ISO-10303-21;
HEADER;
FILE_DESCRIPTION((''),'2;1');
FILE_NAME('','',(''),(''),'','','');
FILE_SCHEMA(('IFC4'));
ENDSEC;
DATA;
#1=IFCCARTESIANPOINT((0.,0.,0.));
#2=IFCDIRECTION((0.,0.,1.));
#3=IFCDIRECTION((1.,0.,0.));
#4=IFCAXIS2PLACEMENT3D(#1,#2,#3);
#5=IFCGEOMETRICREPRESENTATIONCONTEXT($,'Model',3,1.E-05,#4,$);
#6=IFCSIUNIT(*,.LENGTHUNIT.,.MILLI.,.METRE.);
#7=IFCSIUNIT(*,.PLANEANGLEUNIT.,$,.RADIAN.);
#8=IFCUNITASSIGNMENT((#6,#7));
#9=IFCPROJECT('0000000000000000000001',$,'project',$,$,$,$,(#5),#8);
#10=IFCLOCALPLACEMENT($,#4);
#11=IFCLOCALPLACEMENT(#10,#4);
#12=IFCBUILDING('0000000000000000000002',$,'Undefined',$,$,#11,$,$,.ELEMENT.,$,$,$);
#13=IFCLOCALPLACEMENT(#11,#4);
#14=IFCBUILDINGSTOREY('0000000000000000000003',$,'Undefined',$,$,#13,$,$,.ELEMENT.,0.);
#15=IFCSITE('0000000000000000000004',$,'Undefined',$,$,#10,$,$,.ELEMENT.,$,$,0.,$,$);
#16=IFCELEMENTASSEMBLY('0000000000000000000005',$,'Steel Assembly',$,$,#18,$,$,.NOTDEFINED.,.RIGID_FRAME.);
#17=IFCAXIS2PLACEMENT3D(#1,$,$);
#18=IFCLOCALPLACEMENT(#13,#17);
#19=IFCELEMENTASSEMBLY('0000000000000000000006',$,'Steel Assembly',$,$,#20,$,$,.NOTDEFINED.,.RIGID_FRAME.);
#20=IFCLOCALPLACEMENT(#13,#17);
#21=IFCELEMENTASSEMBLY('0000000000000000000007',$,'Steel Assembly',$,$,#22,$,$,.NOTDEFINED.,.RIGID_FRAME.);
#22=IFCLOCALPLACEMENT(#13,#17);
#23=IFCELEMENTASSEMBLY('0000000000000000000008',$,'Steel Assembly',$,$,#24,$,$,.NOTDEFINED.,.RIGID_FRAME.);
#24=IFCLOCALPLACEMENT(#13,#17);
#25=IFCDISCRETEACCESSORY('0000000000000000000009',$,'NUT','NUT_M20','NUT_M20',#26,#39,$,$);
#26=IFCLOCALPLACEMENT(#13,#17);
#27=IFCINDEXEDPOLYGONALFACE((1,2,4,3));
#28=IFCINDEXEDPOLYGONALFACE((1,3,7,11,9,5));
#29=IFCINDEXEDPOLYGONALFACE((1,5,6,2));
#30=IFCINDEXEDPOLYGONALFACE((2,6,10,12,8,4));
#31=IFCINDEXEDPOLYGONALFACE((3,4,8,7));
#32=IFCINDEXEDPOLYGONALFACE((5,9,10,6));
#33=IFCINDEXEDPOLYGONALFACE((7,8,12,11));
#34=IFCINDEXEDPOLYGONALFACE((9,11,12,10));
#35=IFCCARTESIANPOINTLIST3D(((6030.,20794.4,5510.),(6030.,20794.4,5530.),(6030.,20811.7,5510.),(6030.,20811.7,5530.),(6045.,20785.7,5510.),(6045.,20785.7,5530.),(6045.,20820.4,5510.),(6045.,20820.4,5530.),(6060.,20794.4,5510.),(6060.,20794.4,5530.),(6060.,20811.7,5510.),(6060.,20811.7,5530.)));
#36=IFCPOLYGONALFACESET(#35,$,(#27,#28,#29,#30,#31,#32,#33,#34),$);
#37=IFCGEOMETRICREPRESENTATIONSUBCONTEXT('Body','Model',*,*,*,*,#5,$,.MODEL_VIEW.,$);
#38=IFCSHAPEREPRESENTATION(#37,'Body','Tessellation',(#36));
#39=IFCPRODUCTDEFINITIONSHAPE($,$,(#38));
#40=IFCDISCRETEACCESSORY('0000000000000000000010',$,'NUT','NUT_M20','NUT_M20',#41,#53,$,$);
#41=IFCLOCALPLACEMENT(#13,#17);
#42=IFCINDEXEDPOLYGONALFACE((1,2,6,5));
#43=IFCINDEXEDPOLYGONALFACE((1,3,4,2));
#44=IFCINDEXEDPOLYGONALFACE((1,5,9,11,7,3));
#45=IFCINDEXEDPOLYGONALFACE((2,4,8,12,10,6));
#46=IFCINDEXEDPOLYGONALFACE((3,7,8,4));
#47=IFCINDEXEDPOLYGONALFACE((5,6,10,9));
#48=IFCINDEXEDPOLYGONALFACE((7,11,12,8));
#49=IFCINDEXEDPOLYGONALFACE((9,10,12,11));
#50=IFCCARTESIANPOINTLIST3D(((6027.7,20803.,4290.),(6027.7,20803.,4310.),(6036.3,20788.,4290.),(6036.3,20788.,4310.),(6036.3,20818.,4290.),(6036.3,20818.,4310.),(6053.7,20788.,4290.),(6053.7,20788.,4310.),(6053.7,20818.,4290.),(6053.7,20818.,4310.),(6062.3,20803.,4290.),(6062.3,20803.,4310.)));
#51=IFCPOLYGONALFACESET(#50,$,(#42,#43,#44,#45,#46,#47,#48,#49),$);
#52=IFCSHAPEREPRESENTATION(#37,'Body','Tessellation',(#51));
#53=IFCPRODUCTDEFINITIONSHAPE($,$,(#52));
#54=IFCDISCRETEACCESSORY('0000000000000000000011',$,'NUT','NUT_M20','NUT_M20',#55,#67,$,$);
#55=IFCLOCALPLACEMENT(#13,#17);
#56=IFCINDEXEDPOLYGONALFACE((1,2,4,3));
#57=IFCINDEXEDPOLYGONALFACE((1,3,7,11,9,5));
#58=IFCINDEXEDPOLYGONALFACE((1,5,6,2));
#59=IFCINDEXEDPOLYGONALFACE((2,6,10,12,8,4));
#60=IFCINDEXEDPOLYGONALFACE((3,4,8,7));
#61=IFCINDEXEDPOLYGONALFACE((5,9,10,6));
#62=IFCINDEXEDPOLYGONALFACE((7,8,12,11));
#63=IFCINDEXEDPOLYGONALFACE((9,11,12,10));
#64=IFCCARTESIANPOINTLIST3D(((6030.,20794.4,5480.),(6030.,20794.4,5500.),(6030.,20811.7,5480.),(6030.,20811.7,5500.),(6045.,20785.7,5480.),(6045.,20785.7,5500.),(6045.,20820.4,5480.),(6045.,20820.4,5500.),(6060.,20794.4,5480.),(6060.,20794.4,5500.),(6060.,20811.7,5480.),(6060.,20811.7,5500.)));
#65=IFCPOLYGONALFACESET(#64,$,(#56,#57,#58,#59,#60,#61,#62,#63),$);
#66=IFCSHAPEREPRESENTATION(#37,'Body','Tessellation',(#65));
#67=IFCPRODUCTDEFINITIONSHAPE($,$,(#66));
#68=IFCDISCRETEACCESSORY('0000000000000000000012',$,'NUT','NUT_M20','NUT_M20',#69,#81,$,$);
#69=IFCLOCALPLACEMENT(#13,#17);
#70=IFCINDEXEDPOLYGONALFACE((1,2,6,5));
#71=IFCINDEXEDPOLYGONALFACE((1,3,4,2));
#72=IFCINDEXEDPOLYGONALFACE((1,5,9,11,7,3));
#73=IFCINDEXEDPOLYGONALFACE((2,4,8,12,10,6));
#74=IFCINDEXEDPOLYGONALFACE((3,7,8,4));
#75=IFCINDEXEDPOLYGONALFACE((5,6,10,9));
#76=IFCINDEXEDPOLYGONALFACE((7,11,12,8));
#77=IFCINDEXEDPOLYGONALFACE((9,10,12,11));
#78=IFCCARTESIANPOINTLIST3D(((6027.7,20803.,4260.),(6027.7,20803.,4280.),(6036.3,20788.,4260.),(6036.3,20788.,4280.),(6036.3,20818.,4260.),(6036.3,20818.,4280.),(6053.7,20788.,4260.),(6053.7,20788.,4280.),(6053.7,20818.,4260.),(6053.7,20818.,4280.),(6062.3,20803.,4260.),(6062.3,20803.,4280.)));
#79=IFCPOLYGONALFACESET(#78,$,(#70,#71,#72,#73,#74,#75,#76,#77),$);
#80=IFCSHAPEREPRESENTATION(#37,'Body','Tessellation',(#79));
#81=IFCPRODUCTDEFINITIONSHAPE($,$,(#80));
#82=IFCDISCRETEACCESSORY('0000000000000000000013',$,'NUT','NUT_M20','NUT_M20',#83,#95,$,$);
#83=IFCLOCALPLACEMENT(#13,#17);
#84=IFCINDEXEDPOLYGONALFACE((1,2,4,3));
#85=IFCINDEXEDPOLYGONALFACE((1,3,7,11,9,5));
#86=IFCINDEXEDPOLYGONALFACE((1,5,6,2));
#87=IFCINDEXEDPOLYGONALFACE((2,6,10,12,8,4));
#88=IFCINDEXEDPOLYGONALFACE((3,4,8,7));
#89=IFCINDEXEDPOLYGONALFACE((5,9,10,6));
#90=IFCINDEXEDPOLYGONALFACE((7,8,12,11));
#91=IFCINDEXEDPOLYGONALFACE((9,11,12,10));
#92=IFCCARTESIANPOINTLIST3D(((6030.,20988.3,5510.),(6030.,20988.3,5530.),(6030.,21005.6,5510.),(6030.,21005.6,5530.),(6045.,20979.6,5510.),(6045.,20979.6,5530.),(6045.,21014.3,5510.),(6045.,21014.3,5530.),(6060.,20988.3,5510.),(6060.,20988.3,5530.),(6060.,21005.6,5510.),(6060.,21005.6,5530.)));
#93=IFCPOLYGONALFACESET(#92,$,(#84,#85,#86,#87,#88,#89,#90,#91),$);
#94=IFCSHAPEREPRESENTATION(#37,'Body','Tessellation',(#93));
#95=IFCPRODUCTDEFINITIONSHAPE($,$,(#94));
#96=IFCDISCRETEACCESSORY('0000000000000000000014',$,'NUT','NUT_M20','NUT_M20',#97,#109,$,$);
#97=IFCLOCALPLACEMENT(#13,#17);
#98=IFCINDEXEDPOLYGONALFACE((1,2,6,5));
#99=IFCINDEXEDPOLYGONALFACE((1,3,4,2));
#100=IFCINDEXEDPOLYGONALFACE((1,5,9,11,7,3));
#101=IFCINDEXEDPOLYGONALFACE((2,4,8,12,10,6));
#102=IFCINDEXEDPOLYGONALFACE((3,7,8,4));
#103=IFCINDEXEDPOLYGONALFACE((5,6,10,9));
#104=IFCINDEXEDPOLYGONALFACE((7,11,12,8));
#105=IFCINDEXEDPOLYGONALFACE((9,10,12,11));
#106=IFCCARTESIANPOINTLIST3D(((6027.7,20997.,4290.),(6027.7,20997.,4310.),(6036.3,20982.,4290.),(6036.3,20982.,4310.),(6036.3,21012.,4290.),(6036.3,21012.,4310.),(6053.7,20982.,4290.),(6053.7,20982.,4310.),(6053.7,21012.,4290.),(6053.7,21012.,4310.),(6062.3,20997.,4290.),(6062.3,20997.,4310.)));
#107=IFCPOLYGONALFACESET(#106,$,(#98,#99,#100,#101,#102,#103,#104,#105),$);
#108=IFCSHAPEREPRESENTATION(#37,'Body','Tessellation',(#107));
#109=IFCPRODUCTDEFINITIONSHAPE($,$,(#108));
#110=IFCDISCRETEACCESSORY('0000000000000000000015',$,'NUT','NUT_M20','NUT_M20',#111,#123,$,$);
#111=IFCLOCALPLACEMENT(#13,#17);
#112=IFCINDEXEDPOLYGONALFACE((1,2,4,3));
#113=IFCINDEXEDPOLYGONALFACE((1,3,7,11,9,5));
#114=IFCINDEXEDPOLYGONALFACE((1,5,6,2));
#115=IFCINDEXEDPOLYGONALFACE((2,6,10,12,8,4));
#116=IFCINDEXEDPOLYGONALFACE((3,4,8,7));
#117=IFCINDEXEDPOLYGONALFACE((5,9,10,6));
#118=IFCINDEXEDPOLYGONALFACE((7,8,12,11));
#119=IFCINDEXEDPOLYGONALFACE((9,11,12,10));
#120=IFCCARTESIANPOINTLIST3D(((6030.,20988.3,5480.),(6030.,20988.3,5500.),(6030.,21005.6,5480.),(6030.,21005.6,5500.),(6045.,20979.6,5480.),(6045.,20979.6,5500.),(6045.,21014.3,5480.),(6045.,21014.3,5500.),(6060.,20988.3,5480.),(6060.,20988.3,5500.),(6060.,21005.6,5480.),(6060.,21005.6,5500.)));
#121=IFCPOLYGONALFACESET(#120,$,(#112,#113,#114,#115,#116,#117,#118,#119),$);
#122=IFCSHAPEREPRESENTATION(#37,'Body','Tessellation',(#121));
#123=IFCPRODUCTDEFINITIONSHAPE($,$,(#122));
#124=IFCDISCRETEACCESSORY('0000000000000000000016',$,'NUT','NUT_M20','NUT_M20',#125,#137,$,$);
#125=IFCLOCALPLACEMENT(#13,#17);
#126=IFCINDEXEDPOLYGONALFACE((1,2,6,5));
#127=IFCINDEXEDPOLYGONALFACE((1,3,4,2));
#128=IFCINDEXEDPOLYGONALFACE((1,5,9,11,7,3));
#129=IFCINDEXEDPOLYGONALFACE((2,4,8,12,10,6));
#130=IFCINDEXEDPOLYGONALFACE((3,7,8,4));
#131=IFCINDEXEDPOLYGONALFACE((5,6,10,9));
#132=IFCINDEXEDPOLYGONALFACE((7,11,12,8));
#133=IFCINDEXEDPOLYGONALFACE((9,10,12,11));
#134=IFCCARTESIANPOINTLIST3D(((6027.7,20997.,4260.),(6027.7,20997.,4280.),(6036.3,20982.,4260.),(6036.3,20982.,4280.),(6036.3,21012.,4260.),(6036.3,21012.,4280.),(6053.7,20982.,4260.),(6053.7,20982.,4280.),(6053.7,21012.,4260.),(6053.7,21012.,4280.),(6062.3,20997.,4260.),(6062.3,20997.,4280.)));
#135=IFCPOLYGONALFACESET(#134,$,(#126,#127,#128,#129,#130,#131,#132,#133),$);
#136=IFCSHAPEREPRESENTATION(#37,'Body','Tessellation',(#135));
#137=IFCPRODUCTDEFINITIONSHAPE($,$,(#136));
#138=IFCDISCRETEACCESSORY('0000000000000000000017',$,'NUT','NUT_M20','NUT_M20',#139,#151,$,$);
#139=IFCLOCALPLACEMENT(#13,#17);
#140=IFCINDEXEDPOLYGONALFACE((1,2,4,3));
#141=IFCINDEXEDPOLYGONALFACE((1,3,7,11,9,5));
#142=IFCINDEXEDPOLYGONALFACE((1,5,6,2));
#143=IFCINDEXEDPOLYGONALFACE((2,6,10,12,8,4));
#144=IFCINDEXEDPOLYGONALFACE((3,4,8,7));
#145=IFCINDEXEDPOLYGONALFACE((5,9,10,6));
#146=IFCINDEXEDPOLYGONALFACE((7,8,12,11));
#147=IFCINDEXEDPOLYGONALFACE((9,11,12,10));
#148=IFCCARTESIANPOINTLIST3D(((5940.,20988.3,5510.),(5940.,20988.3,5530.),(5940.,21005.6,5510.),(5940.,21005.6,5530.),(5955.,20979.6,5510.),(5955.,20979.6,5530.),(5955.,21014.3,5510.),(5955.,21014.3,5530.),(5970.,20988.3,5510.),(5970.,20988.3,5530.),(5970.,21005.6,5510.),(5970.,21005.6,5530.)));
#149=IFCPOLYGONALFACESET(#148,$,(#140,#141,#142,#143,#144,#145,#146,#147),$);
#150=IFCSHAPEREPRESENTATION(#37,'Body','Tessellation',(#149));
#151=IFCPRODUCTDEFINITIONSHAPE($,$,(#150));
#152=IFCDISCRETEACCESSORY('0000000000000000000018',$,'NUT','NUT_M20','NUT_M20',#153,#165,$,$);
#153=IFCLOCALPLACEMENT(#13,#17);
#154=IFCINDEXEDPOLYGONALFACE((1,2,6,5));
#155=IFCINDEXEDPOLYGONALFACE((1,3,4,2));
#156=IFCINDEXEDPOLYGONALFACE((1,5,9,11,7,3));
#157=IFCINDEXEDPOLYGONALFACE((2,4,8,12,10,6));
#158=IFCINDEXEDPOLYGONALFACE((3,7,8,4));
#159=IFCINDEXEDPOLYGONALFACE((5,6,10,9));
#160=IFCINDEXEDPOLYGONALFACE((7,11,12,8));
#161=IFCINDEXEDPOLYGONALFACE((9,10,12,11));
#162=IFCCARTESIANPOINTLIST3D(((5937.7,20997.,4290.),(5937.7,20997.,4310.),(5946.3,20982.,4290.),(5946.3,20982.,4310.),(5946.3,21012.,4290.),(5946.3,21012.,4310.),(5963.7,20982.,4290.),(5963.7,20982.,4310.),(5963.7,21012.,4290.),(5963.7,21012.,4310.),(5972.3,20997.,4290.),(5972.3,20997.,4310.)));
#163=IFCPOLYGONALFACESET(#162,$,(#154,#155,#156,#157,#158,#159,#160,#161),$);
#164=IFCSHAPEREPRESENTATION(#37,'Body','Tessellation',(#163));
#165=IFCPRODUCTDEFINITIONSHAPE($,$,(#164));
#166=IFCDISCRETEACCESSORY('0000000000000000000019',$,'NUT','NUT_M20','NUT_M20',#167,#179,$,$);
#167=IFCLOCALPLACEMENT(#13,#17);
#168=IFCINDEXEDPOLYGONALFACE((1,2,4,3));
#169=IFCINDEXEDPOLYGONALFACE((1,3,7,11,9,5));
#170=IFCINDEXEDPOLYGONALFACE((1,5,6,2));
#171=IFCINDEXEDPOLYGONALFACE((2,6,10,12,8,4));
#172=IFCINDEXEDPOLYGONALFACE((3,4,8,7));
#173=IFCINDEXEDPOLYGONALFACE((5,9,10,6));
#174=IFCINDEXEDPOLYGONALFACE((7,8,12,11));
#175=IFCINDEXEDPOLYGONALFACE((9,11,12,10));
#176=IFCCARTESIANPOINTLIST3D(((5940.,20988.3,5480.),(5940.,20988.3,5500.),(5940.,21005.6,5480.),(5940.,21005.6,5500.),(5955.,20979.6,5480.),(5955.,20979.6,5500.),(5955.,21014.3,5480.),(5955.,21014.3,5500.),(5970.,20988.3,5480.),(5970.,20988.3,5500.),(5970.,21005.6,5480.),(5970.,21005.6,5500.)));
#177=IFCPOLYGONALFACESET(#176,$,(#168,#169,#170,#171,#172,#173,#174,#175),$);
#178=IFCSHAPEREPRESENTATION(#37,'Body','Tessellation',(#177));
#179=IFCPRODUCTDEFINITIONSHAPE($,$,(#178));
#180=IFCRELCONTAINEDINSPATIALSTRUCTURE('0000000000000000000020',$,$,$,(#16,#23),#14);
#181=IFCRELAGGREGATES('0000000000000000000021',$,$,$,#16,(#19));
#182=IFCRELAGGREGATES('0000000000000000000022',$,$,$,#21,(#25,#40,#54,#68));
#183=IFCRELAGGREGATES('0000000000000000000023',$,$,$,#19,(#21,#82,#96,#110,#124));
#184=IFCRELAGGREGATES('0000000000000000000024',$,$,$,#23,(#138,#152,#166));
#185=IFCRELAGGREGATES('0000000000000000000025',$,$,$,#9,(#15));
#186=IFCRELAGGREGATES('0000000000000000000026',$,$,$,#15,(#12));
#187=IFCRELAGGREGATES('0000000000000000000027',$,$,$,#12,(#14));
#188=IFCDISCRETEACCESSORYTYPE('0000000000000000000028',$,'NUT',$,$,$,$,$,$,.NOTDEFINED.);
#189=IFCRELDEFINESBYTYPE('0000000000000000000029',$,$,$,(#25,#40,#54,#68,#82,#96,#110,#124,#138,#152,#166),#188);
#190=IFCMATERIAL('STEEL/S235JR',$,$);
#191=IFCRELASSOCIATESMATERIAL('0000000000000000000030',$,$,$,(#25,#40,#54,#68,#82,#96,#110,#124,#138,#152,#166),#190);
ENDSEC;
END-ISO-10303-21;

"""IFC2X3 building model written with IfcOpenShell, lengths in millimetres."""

from ifc_helpers import new_model, si_unit, frame, origin_with_axes, place, context, subcontext, project, spatial, polyline, outline, extrude, material, type_object, element, aggregate, save


model = new_model("IFC2X3")

# Units and contexts
model_context = context("Model", 3, precision=1e-05, world=origin_with_axes())
body_context = subcontext(model_context, "Body", "Model", "MODEL_VIEW")
ifc_project = project(units=[si_unit("LENGTHUNIT", "METRE", prefix="MILLI"), si_unit("PLANEANGLEUNIT", "RADIAN")], contexts=[model_context])

# Site, building, storey
site_placement = place(None, origin_with_axes())
site = spatial("IfcSite", under=ifc_project, at=site_placement, Name="Undefined", CompositionType="ELEMENT", RefElevation=0.0)
building_placement = place(site_placement, origin_with_axes())
building = spatial("IfcBuilding", under=site, at=building_placement, Name="Undefined", CompositionType="ELEMENT")
storey_placement = place(building_placement, origin_with_axes())
storey = spatial("IfcBuildingStorey", under=building, at=storey_placement, Name="Undefined", CompositionType="ELEMENT", Elevation=0.0)

# Element assemblies
assembly_1_placement = place(storey_placement, origin_with_axes())
assembly_1 = element("IfcElementAssembly", 1, at=assembly_1_placement, inside=storey, Name="Steel Assembly", AssemblyPlace="NOTDEFINED", PredefinedType="RIGID_FRAME")
assembly_2_placement = place(assembly_1_placement, origin_with_axes())
assembly_2 = element("IfcElementAssembly", 2, at=assembly_2_placement, Name="Steel Assembly", AssemblyPlace="NOTDEFINED", PredefinedType="RIGID_FRAME")
assembly_3_placement = place(assembly_2_placement, origin_with_axes())
assembly_3 = element("IfcElementAssembly", 3, at=assembly_3_placement, Name="Steel Assembly", AssemblyPlace="NOTDEFINED", PredefinedType="RIGID_FRAME")

# Element assembly
assembly_4_placement = place(storey_placement, origin_with_axes())
assembly_4 = element("IfcElementAssembly", 4, at=assembly_4_placement, inside=storey, Name="Steel Assembly", AssemblyPlace="NOTDEFINED", PredefinedType="RIGID_FRAME")

# Shared definitions
ifc_material_1 = material(Name="STEEL/S235JR")

aggregate(assembly_1, [assembly_2])

# Discrete accessories
discrete_accessory_type_1 = type_object("IfcDiscreteAccessoryType", Name="NUT")
discrete_accessory_1_placement = place(assembly_3_placement, frame((6045.0, 20803.0, 5530.0), z_axis=(-1.0, 0.0, 0.0), x_axis=(0.0, 0.0, -1.0)))
discrete_accessory_1 = element("IfcDiscreteAccessory", 5, at=discrete_accessory_1_placement, type_object=discrete_accessory_type_1, material=ifc_material_1, Name="NUT", Description="NUT_M20", ObjectType="NUT_M20", context=body_context, shape_type="SweptSolid", body=[
    extrude(outline(polyline([(8.7, 15.0), (17.3, 0.0), (8.7, -15.0), (-8.7, -15.0), (-17.3, 0.0), (-8.7, 15.0), (8.7, 15.0)])), frame((20.0, 0.0, 0.0), z_axis=(-1.0, 0.0, 0.0), x_axis=(0.0, -1.0, 0.0)), (0.0, 0.0, 1.0), 20.0),
])
discrete_accessory_2_placement = place(assembly_3_placement, frame((6045.0, 20803.0, 4310.0), z_axis=(0.0, -1.0, 0.0), x_axis=(0.0, 0.0, -1.0)))
discrete_accessory_2 = element("IfcDiscreteAccessory", 6, at=discrete_accessory_2_placement, type_object=discrete_accessory_type_1, material=ifc_material_1, Name="NUT", Description="NUT_M20", ObjectType="NUT_M20", context=body_context, shape_type="SweptSolid", body=[
    extrude(outline(polyline([(8.7, 15.0), (17.3, 0.0), (8.7, -15.0), (-8.7, -15.0), (-17.3, 0.0), (-8.7, 15.0), (8.7, 15.0)])), frame((20.0, 0.0, 0.0), z_axis=(-1.0, 0.0, 0.0), x_axis=(0.0, -1.0, 0.0)), (0.0, 0.0, 1.0), 20.0),
])
discrete_accessory_3_placement = place(assembly_3_placement, frame((6045.0, 20803.0, 5500.0), z_axis=(-1.0, 0.0, 0.0), x_axis=(0.0, 0.0, -1.0)))
discrete_accessory_3 = element("IfcDiscreteAccessory", 7, at=discrete_accessory_3_placement, type_object=discrete_accessory_type_1, material=ifc_material_1, Name="NUT", Description="NUT_M20", ObjectType="NUT_M20", context=body_context, shape_type="SweptSolid", body=[
    extrude(outline(polyline([(8.7, 15.0), (17.3, 0.0), (8.7, -15.0), (-8.7, -15.0), (-17.3, 0.0), (-8.7, 15.0), (8.7, 15.0)])), frame((20.0, 0.0, 0.0), z_axis=(-1.0, 0.0, 0.0), x_axis=(0.0, -1.0, 0.0)), (0.0, 0.0, 1.0), 20.0),
])
discrete_accessory_4_placement = place(assembly_3_placement, frame((6045.0, 20803.0, 4280.0), z_axis=(0.0, -1.0, 0.0), x_axis=(0.0, 0.0, -1.0)))
discrete_accessory_4 = element("IfcDiscreteAccessory", 8, at=discrete_accessory_4_placement, type_object=discrete_accessory_type_1, material=ifc_material_1, Name="NUT", Description="NUT_M20", ObjectType="NUT_M20", context=body_context, shape_type="SweptSolid", body=[
    extrude(outline(polyline([(8.7, 15.0), (17.3, 0.0), (8.7, -15.0), (-8.7, -15.0), (-17.3, 0.0), (-8.7, 15.0), (8.7, 15.0)])), frame((20.0, 0.0, 0.0), z_axis=(-1.0, 0.0, 0.0), x_axis=(0.0, -1.0, 0.0)), (0.0, 0.0, 1.0), 20.0),
])
discrete_accessory_5_placement = place(assembly_2_placement, frame((6045.0, 20997.0, 5530.0), z_axis=(-1.0, 0.0, 0.0), x_axis=(0.0, 0.0, -1.0)))
discrete_accessory_5 = element("IfcDiscreteAccessory", 9, at=discrete_accessory_5_placement, type_object=discrete_accessory_type_1, material=ifc_material_1, Name="NUT", Description="NUT_M20", ObjectType="NUT_M20", context=body_context, shape_type="SweptSolid", body=[
    extrude(outline(polyline([(8.7, 15.0), (17.3, 0.0), (8.7, -15.0), (-8.7, -15.0), (-17.3, 0.0), (-8.7, 15.0), (8.7, 15.0)])), frame((20.0, 0.0, 0.0), z_axis=(-1.0, 0.0, 0.0), x_axis=(0.0, -1.0, 0.0)), (0.0, 0.0, 1.0), 20.0),
])
discrete_accessory_6_placement = place(assembly_2_placement, frame((6045.0, 20997.0, 4310.0), z_axis=(0.0, 1.0, 0.0), x_axis=(0.0, 0.0, -1.0)))
discrete_accessory_6 = element("IfcDiscreteAccessory", 10, at=discrete_accessory_6_placement, type_object=discrete_accessory_type_1, material=ifc_material_1, Name="NUT", Description="NUT_M20", ObjectType="NUT_M20", context=body_context, shape_type="SweptSolid", body=[
    extrude(outline(polyline([(8.7, 15.0), (17.3, 0.0), (8.7, -15.0), (-8.7, -15.0), (-17.3, 0.0), (-8.7, 15.0), (8.7, 15.0)])), frame((20.0, 0.0, 0.0), z_axis=(-1.0, 0.0, 0.0), x_axis=(0.0, -1.0, 0.0)), (0.0, 0.0, 1.0), 20.0),
])
discrete_accessory_7_placement = place(assembly_2_placement, frame((6045.0, 20997.0, 5500.0), z_axis=(-1.0, 0.0, 0.0), x_axis=(0.0, 0.0, -1.0)))
discrete_accessory_7 = element("IfcDiscreteAccessory", 11, at=discrete_accessory_7_placement, type_object=discrete_accessory_type_1, material=ifc_material_1, Name="NUT", Description="NUT_M20", ObjectType="NUT_M20", context=body_context, shape_type="SweptSolid", body=[
    extrude(outline(polyline([(8.7, 15.0), (17.3, 0.0), (8.7, -15.0), (-8.7, -15.0), (-17.3, 0.0), (-8.7, 15.0), (8.7, 15.0)])), frame((20.0, 0.0, 0.0), z_axis=(-1.0, 0.0, 0.0), x_axis=(0.0, -1.0, 0.0)), (0.0, 0.0, 1.0), 20.0),
])
discrete_accessory_8_placement = place(assembly_2_placement, frame((6045.0, 20997.0, 4280.0), z_axis=(0.0, 1.0, 0.0), x_axis=(0.0, 0.0, -1.0)))
discrete_accessory_8 = element("IfcDiscreteAccessory", 12, at=discrete_accessory_8_placement, type_object=discrete_accessory_type_1, material=ifc_material_1, Name="NUT", Description="NUT_M20", ObjectType="NUT_M20", context=body_context, shape_type="SweptSolid", body=[
    extrude(outline(polyline([(8.7, 15.0), (17.3, 0.0), (8.7, -15.0), (-8.7, -15.0), (-17.3, 0.0), (-8.7, 15.0), (8.7, 15.0)])), frame((20.0, 0.0, 0.0), z_axis=(-1.0, 0.0, 0.0), x_axis=(0.0, -1.0, 0.0)), (0.0, 0.0, 1.0), 20.0),
])
discrete_accessory_9_placement = place(assembly_4_placement, frame((5955.0, 20997.0, 5530.0), z_axis=(-1.0, 0.0, 0.0), x_axis=(0.0, 0.0, -1.0)))
discrete_accessory_9 = element("IfcDiscreteAccessory", 13, at=discrete_accessory_9_placement, type_object=discrete_accessory_type_1, material=ifc_material_1, Name="NUT", Description="NUT_M20", ObjectType="NUT_M20", context=body_context, shape_type="SweptSolid", body=[
    extrude(outline(polyline([(8.7, 15.0), (17.3, 0.0), (8.7, -15.0), (-8.7, -15.0), (-17.3, 0.0), (-8.7, 15.0), (8.7, 15.0)])), frame((20.0, 0.0, 0.0), z_axis=(-1.0, 0.0, 0.0), x_axis=(0.0, -1.0, 0.0)), (0.0, 0.0, 1.0), 20.0),
])
discrete_accessory_10_placement = place(assembly_4_placement, frame((5955.0, 20997.0, 4310.0), z_axis=(0.0, 1.0, 0.0), x_axis=(0.0, 0.0, -1.0)))
discrete_accessory_10 = element("IfcDiscreteAccessory", 14, at=discrete_accessory_10_placement, type_object=discrete_accessory_type_1, material=ifc_material_1, Name="NUT", Description="NUT_M20", ObjectType="NUT_M20", context=body_context, shape_type="SweptSolid", body=[
    extrude(outline(polyline([(8.7, 15.0), (17.3, 0.0), (8.7, -15.0), (-8.7, -15.0), (-17.3, 0.0), (-8.7, 15.0), (8.7, 15.0)])), frame((20.0, 0.0, 0.0), z_axis=(-1.0, 0.0, 0.0), x_axis=(0.0, -1.0, 0.0)), (0.0, 0.0, 1.0), 20.0),
])
discrete_accessory_11_placement = place(assembly_4_placement, frame((5955.0, 20997.0, 5500.0), z_axis=(-1.0, 0.0, 0.0), x_axis=(0.0, 0.0, -1.0)))
discrete_accessory_11 = element("IfcDiscreteAccessory", 15, at=discrete_accessory_11_placement, type_object=discrete_accessory_type_1, material=ifc_material_1, Name="NUT", Description="NUT_M20", ObjectType="NUT_M20", context=body_context, shape_type="SweptSolid", body=[
    extrude(outline(polyline([(8.7, 15.0), (17.3, 0.0), (8.7, -15.0), (-8.7, -15.0), (-17.3, 0.0), (-8.7, 15.0), (8.7, 15.0)])), frame((20.0, 0.0, 0.0), z_axis=(-1.0, 0.0, 0.0), x_axis=(0.0, -1.0, 0.0)), (0.0, 0.0, 1.0), 20.0),
])
aggregate(assembly_3, [discrete_accessory_1, discrete_accessory_2, discrete_accessory_3, discrete_accessory_4])
aggregate(assembly_2, [assembly_3, discrete_accessory_5, discrete_accessory_6, discrete_accessory_7, discrete_accessory_8])
aggregate(assembly_4, [discrete_accessory_9, discrete_accessory_10, discrete_accessory_11])

save(model, "model.ifc")
